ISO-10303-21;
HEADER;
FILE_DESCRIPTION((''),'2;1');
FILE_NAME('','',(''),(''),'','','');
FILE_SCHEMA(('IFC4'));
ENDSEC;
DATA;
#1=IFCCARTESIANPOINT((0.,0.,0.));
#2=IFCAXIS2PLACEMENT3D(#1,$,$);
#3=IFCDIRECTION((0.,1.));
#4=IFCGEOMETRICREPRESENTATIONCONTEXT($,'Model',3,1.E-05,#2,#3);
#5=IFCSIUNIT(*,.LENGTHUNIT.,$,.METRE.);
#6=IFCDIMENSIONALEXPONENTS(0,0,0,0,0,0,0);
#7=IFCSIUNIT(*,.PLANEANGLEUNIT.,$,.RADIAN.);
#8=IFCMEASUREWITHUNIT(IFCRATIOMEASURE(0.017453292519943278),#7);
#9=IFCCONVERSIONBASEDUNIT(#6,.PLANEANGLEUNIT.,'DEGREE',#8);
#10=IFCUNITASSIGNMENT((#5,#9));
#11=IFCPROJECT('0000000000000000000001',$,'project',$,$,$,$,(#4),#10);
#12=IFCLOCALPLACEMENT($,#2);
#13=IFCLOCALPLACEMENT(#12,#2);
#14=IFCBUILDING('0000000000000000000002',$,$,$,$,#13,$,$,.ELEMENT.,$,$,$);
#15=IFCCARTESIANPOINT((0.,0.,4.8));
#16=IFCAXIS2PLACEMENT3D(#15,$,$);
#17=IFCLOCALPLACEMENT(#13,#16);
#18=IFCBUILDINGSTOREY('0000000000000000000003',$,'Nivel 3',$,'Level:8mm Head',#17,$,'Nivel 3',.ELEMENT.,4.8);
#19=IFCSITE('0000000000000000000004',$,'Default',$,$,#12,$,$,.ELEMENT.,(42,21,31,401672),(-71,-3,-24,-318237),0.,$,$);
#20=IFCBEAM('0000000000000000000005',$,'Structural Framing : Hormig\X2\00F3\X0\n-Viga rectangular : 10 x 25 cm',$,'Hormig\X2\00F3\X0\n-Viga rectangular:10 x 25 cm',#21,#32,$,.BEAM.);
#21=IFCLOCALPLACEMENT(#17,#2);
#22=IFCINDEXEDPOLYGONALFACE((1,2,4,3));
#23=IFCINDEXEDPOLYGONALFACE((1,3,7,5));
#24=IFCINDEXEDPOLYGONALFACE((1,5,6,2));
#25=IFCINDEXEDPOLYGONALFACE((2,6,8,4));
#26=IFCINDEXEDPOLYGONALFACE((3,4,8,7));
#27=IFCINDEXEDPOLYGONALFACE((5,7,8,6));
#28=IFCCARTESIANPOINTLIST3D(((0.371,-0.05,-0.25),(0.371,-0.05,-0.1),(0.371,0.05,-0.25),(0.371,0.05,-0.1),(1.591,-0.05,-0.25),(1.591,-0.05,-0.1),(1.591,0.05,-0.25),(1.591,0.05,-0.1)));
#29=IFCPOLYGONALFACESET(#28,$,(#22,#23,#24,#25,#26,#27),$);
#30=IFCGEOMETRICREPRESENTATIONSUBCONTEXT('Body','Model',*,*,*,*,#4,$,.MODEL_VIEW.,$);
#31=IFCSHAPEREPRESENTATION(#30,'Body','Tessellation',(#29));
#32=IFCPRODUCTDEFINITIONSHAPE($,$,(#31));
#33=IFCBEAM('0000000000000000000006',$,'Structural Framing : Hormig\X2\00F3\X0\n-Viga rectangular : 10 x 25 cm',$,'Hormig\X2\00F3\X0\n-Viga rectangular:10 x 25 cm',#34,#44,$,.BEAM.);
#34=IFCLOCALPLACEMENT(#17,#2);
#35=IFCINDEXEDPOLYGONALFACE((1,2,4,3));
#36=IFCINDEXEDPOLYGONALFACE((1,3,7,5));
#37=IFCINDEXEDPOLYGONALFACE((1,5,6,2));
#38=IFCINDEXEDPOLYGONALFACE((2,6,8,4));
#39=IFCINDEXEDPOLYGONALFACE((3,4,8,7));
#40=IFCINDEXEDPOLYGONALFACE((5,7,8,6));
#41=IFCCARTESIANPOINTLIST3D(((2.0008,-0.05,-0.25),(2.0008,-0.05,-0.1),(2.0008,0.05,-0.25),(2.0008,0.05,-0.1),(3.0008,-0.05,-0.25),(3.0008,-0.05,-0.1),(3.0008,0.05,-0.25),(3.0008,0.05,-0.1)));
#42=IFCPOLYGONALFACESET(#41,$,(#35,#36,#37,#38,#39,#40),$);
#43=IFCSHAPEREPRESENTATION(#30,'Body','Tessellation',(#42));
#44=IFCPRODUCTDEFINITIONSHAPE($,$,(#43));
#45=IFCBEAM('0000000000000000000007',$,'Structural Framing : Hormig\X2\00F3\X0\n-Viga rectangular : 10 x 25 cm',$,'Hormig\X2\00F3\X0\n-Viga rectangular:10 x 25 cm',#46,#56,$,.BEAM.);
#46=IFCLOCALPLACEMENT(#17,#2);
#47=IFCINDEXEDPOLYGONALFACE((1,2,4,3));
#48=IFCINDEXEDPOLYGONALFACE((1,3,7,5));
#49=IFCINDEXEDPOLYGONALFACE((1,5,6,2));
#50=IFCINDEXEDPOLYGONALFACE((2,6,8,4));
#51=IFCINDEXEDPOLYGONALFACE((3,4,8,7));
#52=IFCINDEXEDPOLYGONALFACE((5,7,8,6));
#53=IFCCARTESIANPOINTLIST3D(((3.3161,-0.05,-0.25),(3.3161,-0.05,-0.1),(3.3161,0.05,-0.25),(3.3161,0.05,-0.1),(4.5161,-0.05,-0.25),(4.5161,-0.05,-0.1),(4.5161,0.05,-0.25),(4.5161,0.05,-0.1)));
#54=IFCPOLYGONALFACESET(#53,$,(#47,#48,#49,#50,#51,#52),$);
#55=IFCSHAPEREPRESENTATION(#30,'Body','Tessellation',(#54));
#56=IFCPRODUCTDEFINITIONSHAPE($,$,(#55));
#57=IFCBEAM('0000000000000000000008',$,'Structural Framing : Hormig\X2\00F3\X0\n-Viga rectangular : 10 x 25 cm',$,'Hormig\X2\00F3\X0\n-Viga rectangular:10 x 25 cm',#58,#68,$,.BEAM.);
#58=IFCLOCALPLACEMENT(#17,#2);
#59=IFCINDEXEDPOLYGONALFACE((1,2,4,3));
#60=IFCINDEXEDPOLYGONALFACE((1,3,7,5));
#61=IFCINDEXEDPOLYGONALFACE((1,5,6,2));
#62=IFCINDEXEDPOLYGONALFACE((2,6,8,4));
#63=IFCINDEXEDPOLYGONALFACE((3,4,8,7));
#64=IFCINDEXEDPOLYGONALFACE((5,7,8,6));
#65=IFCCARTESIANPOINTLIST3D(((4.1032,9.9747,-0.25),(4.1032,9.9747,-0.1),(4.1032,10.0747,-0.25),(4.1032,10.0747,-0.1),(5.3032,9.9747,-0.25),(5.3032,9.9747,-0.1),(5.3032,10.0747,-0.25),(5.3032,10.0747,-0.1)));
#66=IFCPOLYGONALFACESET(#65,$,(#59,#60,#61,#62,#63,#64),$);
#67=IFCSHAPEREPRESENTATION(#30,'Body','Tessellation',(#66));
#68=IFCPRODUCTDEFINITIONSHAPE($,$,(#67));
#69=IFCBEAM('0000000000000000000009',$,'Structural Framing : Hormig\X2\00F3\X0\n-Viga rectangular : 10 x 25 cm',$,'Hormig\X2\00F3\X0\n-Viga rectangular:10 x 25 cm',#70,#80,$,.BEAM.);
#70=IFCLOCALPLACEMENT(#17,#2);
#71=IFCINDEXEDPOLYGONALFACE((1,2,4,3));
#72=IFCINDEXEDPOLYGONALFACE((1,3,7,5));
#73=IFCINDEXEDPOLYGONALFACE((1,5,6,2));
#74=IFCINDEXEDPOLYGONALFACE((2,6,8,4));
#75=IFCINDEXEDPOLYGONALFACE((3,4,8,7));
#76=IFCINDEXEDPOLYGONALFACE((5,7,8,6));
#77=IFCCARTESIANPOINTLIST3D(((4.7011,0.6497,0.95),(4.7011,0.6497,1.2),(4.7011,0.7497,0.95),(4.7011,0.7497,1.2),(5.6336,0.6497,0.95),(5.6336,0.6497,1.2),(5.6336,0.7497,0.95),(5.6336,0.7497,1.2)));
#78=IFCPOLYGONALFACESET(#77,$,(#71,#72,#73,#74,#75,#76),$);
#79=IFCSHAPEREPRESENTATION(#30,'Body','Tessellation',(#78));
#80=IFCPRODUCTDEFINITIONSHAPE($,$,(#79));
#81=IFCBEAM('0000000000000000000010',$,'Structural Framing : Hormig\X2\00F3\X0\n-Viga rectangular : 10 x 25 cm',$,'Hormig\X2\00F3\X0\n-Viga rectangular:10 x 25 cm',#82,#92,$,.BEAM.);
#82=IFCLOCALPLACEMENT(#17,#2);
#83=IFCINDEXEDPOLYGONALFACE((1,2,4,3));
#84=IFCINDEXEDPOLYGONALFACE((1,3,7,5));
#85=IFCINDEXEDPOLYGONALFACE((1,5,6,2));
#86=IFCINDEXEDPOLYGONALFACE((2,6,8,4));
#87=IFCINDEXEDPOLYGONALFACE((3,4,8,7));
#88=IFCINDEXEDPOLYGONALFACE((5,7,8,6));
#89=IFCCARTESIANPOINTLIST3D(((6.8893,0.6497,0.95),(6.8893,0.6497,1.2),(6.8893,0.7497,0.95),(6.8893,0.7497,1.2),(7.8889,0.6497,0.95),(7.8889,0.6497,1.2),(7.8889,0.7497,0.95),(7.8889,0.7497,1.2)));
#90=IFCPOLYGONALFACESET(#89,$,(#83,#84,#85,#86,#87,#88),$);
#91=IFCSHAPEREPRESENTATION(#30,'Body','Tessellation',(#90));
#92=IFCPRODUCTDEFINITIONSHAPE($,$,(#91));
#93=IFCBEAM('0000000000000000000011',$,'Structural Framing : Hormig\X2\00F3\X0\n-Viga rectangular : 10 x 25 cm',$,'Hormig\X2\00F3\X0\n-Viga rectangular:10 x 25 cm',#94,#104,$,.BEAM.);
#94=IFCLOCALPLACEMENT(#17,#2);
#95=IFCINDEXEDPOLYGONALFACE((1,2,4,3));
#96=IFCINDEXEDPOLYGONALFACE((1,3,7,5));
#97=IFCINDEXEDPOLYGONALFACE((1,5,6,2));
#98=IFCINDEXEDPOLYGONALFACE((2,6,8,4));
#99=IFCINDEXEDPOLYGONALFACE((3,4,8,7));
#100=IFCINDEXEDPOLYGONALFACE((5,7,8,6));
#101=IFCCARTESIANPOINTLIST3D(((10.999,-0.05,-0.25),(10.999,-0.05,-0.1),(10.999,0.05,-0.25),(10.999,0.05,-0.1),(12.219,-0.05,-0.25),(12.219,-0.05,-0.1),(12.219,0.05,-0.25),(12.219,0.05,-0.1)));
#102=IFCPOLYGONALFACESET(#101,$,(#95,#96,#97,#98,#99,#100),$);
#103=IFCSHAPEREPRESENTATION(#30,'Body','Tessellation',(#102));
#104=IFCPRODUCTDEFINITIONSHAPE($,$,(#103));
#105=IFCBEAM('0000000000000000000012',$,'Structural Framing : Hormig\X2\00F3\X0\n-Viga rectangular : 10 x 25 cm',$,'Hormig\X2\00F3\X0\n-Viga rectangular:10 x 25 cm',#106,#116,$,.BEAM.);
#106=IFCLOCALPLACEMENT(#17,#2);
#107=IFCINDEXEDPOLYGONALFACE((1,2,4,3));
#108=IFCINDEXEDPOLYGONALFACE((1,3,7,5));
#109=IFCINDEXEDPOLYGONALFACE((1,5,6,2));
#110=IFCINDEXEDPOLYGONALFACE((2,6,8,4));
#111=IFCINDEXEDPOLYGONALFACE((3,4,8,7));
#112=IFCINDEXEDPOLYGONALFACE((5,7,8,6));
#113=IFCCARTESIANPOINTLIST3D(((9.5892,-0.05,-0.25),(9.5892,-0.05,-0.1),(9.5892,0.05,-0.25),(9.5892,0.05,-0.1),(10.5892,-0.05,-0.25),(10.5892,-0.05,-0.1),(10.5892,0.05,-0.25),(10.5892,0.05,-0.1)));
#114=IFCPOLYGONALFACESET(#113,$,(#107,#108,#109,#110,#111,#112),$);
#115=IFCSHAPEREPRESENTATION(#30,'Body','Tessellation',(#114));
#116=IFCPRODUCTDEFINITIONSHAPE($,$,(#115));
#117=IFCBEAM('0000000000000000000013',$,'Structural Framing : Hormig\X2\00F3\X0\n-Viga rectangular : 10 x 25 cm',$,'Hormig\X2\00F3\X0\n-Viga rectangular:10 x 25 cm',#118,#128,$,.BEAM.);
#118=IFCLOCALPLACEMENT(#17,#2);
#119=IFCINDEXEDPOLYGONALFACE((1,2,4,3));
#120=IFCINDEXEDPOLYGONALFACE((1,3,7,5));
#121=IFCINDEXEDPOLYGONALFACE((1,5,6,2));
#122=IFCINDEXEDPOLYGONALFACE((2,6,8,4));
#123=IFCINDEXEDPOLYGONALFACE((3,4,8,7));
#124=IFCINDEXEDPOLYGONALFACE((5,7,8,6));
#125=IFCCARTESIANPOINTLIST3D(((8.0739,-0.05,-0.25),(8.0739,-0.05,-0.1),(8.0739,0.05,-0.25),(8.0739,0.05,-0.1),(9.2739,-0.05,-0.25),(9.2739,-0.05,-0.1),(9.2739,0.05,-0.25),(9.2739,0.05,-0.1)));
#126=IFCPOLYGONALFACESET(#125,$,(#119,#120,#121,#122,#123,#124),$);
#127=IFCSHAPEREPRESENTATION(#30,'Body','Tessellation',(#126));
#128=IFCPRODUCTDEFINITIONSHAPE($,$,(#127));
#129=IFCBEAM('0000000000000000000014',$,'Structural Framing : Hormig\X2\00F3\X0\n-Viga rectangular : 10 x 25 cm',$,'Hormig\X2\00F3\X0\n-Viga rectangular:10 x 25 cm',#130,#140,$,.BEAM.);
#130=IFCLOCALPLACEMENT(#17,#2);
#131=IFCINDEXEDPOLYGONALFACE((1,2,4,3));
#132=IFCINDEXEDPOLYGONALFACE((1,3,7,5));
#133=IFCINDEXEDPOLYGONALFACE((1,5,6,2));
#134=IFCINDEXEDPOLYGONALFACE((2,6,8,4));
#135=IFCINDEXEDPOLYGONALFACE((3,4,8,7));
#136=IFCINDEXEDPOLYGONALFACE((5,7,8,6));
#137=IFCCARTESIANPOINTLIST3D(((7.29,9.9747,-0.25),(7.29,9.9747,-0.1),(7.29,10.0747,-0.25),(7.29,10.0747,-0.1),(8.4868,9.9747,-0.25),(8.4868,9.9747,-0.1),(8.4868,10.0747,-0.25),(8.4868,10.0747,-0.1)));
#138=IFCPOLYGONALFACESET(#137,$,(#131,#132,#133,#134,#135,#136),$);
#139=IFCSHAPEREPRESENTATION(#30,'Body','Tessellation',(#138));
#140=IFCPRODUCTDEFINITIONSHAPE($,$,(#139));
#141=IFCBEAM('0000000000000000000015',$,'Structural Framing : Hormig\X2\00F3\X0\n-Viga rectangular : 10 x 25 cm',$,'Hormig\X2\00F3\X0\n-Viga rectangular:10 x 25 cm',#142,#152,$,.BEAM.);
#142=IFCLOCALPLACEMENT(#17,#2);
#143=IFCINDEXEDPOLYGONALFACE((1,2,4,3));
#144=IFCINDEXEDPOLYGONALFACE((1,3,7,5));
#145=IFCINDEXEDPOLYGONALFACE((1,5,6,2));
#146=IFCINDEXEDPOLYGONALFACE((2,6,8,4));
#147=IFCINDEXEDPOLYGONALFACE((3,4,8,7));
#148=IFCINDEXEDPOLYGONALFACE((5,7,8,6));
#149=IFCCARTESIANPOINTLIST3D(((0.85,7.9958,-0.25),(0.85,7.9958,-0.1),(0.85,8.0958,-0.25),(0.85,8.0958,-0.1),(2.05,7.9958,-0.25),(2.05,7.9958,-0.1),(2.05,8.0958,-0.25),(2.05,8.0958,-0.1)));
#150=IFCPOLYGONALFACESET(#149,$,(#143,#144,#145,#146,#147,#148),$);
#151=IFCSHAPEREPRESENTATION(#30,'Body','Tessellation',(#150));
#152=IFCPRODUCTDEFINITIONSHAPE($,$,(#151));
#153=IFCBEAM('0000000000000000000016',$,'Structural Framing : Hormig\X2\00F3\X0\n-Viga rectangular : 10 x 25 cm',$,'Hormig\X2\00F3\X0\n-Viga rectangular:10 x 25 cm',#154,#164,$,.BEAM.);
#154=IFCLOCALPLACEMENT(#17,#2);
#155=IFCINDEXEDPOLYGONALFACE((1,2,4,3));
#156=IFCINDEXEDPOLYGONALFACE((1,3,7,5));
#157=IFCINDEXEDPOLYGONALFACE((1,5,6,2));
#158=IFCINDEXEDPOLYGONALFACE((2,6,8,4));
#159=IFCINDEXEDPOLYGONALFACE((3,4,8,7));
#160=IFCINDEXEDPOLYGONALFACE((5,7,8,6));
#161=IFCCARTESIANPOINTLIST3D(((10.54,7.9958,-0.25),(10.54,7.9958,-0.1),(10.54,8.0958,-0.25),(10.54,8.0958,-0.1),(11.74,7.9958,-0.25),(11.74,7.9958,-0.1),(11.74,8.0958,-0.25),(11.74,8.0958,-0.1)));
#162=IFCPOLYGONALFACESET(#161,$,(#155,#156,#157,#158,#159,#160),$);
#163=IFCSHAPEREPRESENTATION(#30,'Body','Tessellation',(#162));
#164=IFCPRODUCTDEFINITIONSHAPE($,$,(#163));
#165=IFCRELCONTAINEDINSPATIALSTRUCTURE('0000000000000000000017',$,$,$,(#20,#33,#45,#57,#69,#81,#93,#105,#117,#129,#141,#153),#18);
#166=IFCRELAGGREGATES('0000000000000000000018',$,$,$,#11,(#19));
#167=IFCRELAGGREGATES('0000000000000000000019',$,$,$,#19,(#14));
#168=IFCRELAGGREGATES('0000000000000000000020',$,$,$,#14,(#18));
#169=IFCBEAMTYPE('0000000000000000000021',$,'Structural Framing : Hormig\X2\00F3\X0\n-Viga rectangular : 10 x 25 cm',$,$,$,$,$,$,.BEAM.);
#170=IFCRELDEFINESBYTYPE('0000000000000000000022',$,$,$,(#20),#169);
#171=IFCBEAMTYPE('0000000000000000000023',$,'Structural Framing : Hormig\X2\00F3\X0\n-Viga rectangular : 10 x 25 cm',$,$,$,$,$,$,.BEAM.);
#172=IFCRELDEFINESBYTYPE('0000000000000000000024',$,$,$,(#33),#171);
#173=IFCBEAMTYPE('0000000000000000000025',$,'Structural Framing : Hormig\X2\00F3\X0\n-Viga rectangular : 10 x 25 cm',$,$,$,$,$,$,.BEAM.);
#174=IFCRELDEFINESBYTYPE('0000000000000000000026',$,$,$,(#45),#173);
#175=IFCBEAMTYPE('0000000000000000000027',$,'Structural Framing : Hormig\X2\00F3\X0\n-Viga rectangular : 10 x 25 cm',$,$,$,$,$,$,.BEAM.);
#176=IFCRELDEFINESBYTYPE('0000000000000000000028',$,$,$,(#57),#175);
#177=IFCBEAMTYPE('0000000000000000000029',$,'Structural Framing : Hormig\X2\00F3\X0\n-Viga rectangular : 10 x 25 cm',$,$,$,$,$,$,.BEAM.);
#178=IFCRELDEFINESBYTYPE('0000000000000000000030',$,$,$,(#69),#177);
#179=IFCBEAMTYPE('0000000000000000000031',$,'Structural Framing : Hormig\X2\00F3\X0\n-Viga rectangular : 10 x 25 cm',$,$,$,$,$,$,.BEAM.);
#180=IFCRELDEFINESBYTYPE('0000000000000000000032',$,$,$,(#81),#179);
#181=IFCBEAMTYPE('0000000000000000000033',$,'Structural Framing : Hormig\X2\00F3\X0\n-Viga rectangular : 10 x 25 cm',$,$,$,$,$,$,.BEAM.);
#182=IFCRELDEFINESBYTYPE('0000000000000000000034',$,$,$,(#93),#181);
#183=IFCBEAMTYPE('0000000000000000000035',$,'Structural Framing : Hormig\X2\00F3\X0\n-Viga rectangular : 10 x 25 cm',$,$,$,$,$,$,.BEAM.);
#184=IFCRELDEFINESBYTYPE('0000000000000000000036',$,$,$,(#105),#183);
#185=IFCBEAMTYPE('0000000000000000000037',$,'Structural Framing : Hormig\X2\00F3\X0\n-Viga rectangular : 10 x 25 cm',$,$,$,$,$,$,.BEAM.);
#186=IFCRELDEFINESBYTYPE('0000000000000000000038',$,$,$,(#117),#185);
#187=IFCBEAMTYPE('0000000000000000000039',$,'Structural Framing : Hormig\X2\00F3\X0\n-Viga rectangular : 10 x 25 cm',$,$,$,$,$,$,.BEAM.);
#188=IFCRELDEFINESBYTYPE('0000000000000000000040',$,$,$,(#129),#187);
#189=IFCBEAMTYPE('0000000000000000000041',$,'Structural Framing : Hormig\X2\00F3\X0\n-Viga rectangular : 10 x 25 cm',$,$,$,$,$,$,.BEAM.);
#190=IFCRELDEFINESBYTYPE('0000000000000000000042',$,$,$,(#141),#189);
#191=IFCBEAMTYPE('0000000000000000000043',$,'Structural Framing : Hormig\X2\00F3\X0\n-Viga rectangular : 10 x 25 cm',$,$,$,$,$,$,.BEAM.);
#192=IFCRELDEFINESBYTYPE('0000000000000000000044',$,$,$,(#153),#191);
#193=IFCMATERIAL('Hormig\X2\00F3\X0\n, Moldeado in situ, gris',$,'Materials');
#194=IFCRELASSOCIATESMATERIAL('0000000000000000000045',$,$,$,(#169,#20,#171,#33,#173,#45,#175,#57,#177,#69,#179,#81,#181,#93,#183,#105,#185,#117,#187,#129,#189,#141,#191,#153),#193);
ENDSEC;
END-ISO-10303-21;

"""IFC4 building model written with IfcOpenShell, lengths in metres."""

from ifc_helpers import new_model, entity, si_unit, converted_unit, direction, frame, origin, place, context, subcontext, project, spatial, indexed_curve, outline, extrude, source, transform, mapped, material, type_object, type_shapes, element, save


model = new_model("IFC4")

# Units and contexts
model_context = context("Model", 3, precision=1e-05, world=origin(), true_north=direction((0.0, 1.0)))
body_context = subcontext(model_context, "Body", "Model", "MODEL_VIEW")
ifc_project = project(units=[si_unit("LENGTHUNIT", "METRE"), converted_unit("PLANEANGLEUNIT", "DEGREE", entity("IfcRatioMeasure", 0.017453292519943278), si_unit("PLANEANGLEUNIT", "RADIAN"), dimensions=[0, 0, 0, 0, 0, 0, 0])], contexts=[model_context])

# Site, building, storey
site_placement = place(None, origin())
site = spatial("IfcSite", under=ifc_project, at=site_placement, Name="Default", CompositionType="ELEMENT", RefLatitude=(42, 21, 31, 401672), RefLongitude=(-71, -3, -24, -318237), RefElevation=0.0)
building_placement = place(site_placement, origin())
building = spatial("IfcBuilding", under=site, at=building_placement, CompositionType="ELEMENT")
storey_placement = place(building_placement, frame((0.0, 0.0, 4.8)))
storey = spatial("IfcBuildingStorey", under=building, at=storey_placement, Name="Nivel 3", ObjectType="Level:8mm Head", LongName="Nivel 3", CompositionType="ELEMENT", Elevation=4.8)

# Beams
ifc_material_1 = material(Name="Hormigón, Moldeado in situ, gris", Category="Materials")
beam_type_1 = type_object("IfcBeamType", Name="Structural Framing : Hormigón-Viga rectangular : 10 x 25 cm", PredefinedType="BEAM", material=ifc_material_1)
shared_shape_1 = source(origin(), body_context, "Body", "SweptSolid", [
    extrude(outline(indexed_curve([(-0.075, -0.05), (0.075, -0.05), (0.075, 0.05), (-0.075, 0.05), (-0.075, -0.05)], self_intersect=False)), frame((0.371, 0.0, 4.625), z_axis=(1.0, 0.0, 0.0), x_axis=(0.0, 0.0, -1.0)), (0.0, 0.0, 1.0), 1.22),
])
type_shapes(beam_type_1, [shared_shape_1])
beam_1_placement = place(storey_placement, frame((0.0, 0.0, -4.8)))
element("IfcBeam", 1, at=beam_1_placement, inside=storey, type_object=beam_type_1, material=ifc_material_1, Name="Structural Framing : Hormigón-Viga rectangular : 10 x 25 cm", ObjectType="Hormigón-Viga rectangular:10 x 25 cm", PredefinedType="BEAM", context=body_context, shape_type="MappedRepresentation", body=[
    mapped(shared_shape_1, transform((0.0, 0.0, 0.0), scale=1.0)),
])
beam_type_2 = type_object("IfcBeamType", Name="Structural Framing : Hormigón-Viga rectangular : 10 x 25 cm", PredefinedType="BEAM", material=ifc_material_1)
shared_shape_2 = source(origin(), body_context, "Body", "SweptSolid", [
    extrude(outline(indexed_curve([(-0.075, -0.05), (0.075, -0.05), (0.075, 0.05), (-0.075, 0.05), (-0.075, -0.05)], self_intersect=False)), frame((2.0008, 0.0, 4.625), z_axis=(1.0, 0.0, 0.0), x_axis=(0.0, 0.0, -1.0)), (0.0, 0.0, 1.0), 1.0),
])
type_shapes(beam_type_2, [shared_shape_2])
beam_2_placement = place(storey_placement, frame((0.0, 0.0, -4.8)))
element("IfcBeam", 2, at=beam_2_placement, inside=storey, type_object=beam_type_2, material=ifc_material_1, Name="Structural Framing : Hormigón-Viga rectangular : 10 x 25 cm", ObjectType="Hormigón-Viga rectangular:10 x 25 cm", PredefinedType="BEAM", context=body_context, shape_type="MappedRepresentation", body=[
    mapped(shared_shape_2, transform((0.0, 0.0, 0.0), scale=1.0)),
])
beam_type_3 = type_object("IfcBeamType", Name="Structural Framing : Hormigón-Viga rectangular : 10 x 25 cm", PredefinedType="BEAM", material=ifc_material_1)
shared_shape_3 = source(origin(), body_context, "Body", "SweptSolid", [
    extrude(outline(indexed_curve([(-0.075, -0.05), (0.075, -0.05), (0.075, 0.05), (-0.075, 0.05), (-0.075, -0.05)], self_intersect=False)), frame((3.3161, 0.0, 4.625), z_axis=(1.0, 0.0, 0.0), x_axis=(0.0, 0.0, -1.0)), (0.0, 0.0, 1.0), 1.2),
])
type_shapes(beam_type_3, [shared_shape_3])
beam_3_placement = place(storey_placement, frame((0.0, 0.0, -4.8)))
element("IfcBeam", 3, at=beam_3_placement, inside=storey, type_object=beam_type_3, material=ifc_material_1, Name="Structural Framing : Hormigón-Viga rectangular : 10 x 25 cm", ObjectType="Hormigón-Viga rectangular:10 x 25 cm", PredefinedType="BEAM", context=body_context, shape_type="MappedRepresentation", body=[
    mapped(shared_shape_3, transform((0.0, 0.0, 0.0), scale=1.0)),
])
beam_type_4 = type_object("IfcBeamType", Name="Structural Framing : Hormigón-Viga rectangular : 10 x 25 cm", PredefinedType="BEAM", material=ifc_material_1)
shared_shape_4 = source(origin(), body_context, "Body", "SweptSolid", [
    extrude(outline(indexed_curve([(-0.075, -0.05), (0.075, -0.05), (0.075, 0.05), (-0.075, 0.05), (-0.075, -0.05)], self_intersect=False)), frame((5.3032, 10.0247, 4.625), z_axis=(-1.0, 0.0, 0.0), x_axis=(0.0, 0.0, -1.0)), (0.0, 0.0, 1.0), 1.2),
])
type_shapes(beam_type_4, [shared_shape_4])
beam_4_placement = place(storey_placement, frame((0.0, 0.0, -4.8)))
element("IfcBeam", 4, at=beam_4_placement, inside=storey, type_object=beam_type_4, material=ifc_material_1, Name="Structural Framing : Hormigón-Viga rectangular : 10 x 25 cm", ObjectType="Hormigón-Viga rectangular:10 x 25 cm", PredefinedType="BEAM", context=body_context, shape_type="MappedRepresentation", body=[
    mapped(shared_shape_4, transform((0.0, 0.0, 0.0), scale=1.0)),
])
beam_type_5 = type_object("IfcBeamType", Name="Structural Framing : Hormigón-Viga rectangular : 10 x 25 cm", PredefinedType="BEAM", material=ifc_material_1)
shared_shape_5 = source(origin(), body_context, "Body", "SweptSolid", [
    extrude(outline(indexed_curve([(-0.125, -0.05), (0.125, -0.05), (0.125, 0.05), (-0.125, 0.05), (-0.125, -0.05)], self_intersect=False)), frame((5.6336, 0.6997, 5.875), z_axis=(-1.0, 0.0, 0.0), x_axis=(0.0, 0.0, -1.0)), (0.0, 0.0, 1.0), 0.9325),
])
type_shapes(beam_type_5, [shared_shape_5])
beam_5_placement = place(storey_placement, frame((0.0, 0.0, -4.8)))
element("IfcBeam", 5, at=beam_5_placement, inside=storey, type_object=beam_type_5, material=ifc_material_1, Name="Structural Framing : Hormigón-Viga rectangular : 10 x 25 cm", ObjectType="Hormigón-Viga rectangular:10 x 25 cm", PredefinedType="BEAM", context=body_context, shape_type="MappedRepresentation", body=[
    mapped(shared_shape_5, transform((0.0, 0.0, 0.0), scale=1.0)),
])
beam_type_6 = type_object("IfcBeamType", Name="Structural Framing : Hormigón-Viga rectangular : 10 x 25 cm", PredefinedType="BEAM", material=ifc_material_1)
shared_shape_6 = source(origin(), body_context, "Body", "SweptSolid", [
    extrude(outline(indexed_curve([(-0.125, -0.05), (0.125, -0.05), (0.125, 0.05), (-0.125, 0.05), (-0.125, -0.05)], self_intersect=False)), frame((7.8889, 0.6997, 5.875), z_axis=(-1.0, 0.0, 0.0), x_axis=(0.0, 0.0, -1.0)), (0.0, 0.0, 1.0), 0.9996),
])
type_shapes(beam_type_6, [shared_shape_6])
beam_6_placement = place(storey_placement, frame((0.0, 0.0, -4.8)))
element("IfcBeam", 6, at=beam_6_placement, inside=storey, type_object=beam_type_6, material=ifc_material_1, Name="Structural Framing : Hormigón-Viga rectangular : 10 x 25 cm", ObjectType="Hormigón-Viga rectangular:10 x 25 cm", PredefinedType="BEAM", context=body_context, shape_type="MappedRepresentation", body=[
    mapped(shared_shape_6, transform((0.0, 0.0, 0.0), scale=1.0)),
])
beam_type_7 = type_object("IfcBeamType", Name="Structural Framing : Hormigón-Viga rectangular : 10 x 25 cm", PredefinedType="BEAM", material=ifc_material_1)
shared_shape_7 = source(origin(), body_context, "Body", "SweptSolid", [
    extrude(outline(indexed_curve([(-0.075, -0.05), (0.075, -0.05), (0.075, 0.05), (-0.075, 0.05), (-0.075, -0.05)], self_intersect=False)), frame((12.219, 0.0, 4.625), z_axis=(-1.0, 0.0, 0.0), x_axis=(0.0, 0.0, -1.0)), (0.0, 0.0, 1.0), 1.22),
])
type_shapes(beam_type_7, [shared_shape_7])
beam_7_placement = place(storey_placement, frame((0.0, 0.0, -4.8)))
element("IfcBeam", 7, at=beam_7_placement, inside=storey, type_object=beam_type_7, material=ifc_material_1, Name="Structural Framing : Hormigón-Viga rectangular : 10 x 25 cm", ObjectType="Hormigón-Viga rectangular:10 x 25 cm", PredefinedType="BEAM", context=body_context, shape_type="MappedRepresentation", body=[
    mapped(shared_shape_7, transform((0.0, 0.0, 0.0), scale=1.0)),
])
beam_type_8 = type_object("IfcBeamType", Name="Structural Framing : Hormigón-Viga rectangular : 10 x 25 cm", PredefinedType="BEAM", material=ifc_material_1)
shared_shape_8 = source(origin(), body_context, "Body", "SweptSolid", [
    extrude(outline(indexed_curve([(-0.075, -0.05), (0.075, -0.05), (0.075, 0.05), (-0.075, 0.05), (-0.075, -0.05)], self_intersect=False)), frame((10.5892, 0.0, 4.625), z_axis=(-1.0, 0.0, 0.0), x_axis=(0.0, 0.0, -1.0)), (0.0, 0.0, 1.0), 1.0),
])
type_shapes(beam_type_8, [shared_shape_8])
beam_8_placement = place(storey_placement, frame((0.0, 0.0, -4.8)))
element("IfcBeam", 8, at=beam_8_placement, inside=storey, type_object=beam_type_8, material=ifc_material_1, Name="Structural Framing : Hormigón-Viga rectangular : 10 x 25 cm", ObjectType="Hormigón-Viga rectangular:10 x 25 cm", PredefinedType="BEAM", context=body_context, shape_type="MappedRepresentation", body=[
    mapped(shared_shape_8, transform((0.0, 0.0, 0.0), scale=1.0)),
])
beam_type_9 = type_object("IfcBeamType", Name="Structural Framing : Hormigón-Viga rectangular : 10 x 25 cm", PredefinedType="BEAM", material=ifc_material_1)
shared_shape_9 = source(origin(), body_context, "Body", "SweptSolid", [
    extrude(outline(indexed_curve([(-0.075, -0.05), (0.075, -0.05), (0.075, 0.05), (-0.075, 0.05), (-0.075, -0.05)], self_intersect=False)), frame((9.2739, 0.0, 4.625), z_axis=(-1.0, 0.0, 0.0), x_axis=(0.0, 0.0, -1.0)), (0.0, 0.0, 1.0), 1.2),
])
type_shapes(beam_type_9, [shared_shape_9])
beam_9_placement = place(storey_placement, frame((0.0, 0.0, -4.8)))
element("IfcBeam", 9, at=beam_9_placement, inside=storey, type_object=beam_type_9, material=ifc_material_1, Name="Structural Framing : Hormigón-Viga rectangular : 10 x 25 cm", ObjectType="Hormigón-Viga rectangular:10 x 25 cm", PredefinedType="BEAM", context=body_context, shape_type="MappedRepresentation", body=[
    mapped(shared_shape_9, transform((0.0, 0.0, 0.0), scale=1.0)),
])
beam_type_10 = type_object("IfcBeamType", Name="Structural Framing : Hormigón-Viga rectangular : 10 x 25 cm", PredefinedType="BEAM", material=ifc_material_1)
shared_shape_10 = source(origin(), body_context, "Body", "SweptSolid", [
    extrude(outline(indexed_curve([(-0.075, -0.05), (0.075, -0.05), (0.075, 0.05), (-0.075, 0.05), (-0.075, -0.05)], self_intersect=False)), frame((7.29, 10.0247, 4.625), z_axis=(1.0, 0.0, 0.0), x_axis=(0.0, 0.0, -1.0)), (0.0, 0.0, 1.0), 1.1968),
])
type_shapes(beam_type_10, [shared_shape_10])
beam_10_placement = place(storey_placement, frame((0.0, 0.0, -4.8)))
element("IfcBeam", 10, at=beam_10_placement, inside=storey, type_object=beam_type_10, material=ifc_material_1, Name="Structural Framing : Hormigón-Viga rectangular : 10 x 25 cm", ObjectType="Hormigón-Viga rectangular:10 x 25 cm", PredefinedType="BEAM", context=body_context, shape_type="MappedRepresentation", body=[
    mapped(shared_shape_10, transform((0.0, 0.0, 0.0), scale=1.0)),
])
beam_type_11 = type_object("IfcBeamType", Name="Structural Framing : Hormigón-Viga rectangular : 10 x 25 cm", PredefinedType="BEAM", material=ifc_material_1)
shared_shape_11 = source(origin(), body_context, "Body", "SweptSolid", [
    extrude(outline(indexed_curve([(-0.075, -0.05), (0.075, -0.05), (0.075, 0.05), (-0.075, 0.05), (-0.075, -0.05)], self_intersect=False)), frame((2.05, 8.0458, 4.625), z_axis=(-1.0, 0.0, 0.0), x_axis=(0.0, 0.0, -1.0)), (0.0, 0.0, 1.0), 1.2),
])
type_shapes(beam_type_11, [shared_shape_11])
beam_11_placement = place(storey_placement, frame((0.0, 0.0, -4.8)))
element("IfcBeam", 11, at=beam_11_placement, inside=storey, type_object=beam_type_11, material=ifc_material_1, Name="Structural Framing : Hormigón-Viga rectangular : 10 x 25 cm", ObjectType="Hormigón-Viga rectangular:10 x 25 cm", PredefinedType="BEAM", context=body_context, shape_type="MappedRepresentation", body=[
    mapped(shared_shape_11, transform((0.0, 0.0, 0.0), scale=1.0)),
])
beam_type_12 = type_object("IfcBeamType", Name="Structural Framing : Hormigón-Viga rectangular : 10 x 25 cm", PredefinedType="BEAM", material=ifc_material_1)
shared_shape_12 = source(origin(), body_context, "Body", "SweptSolid", [
    extrude(outline(indexed_curve([(-0.075, -0.05), (0.075, -0.05), (0.075, 0.05), (-0.075, 0.05), (-0.075, -0.05)], self_intersect=False)), frame((10.54, 8.0458, 4.625), z_axis=(1.0, 0.0, 0.0), x_axis=(0.0, 0.0, -1.0)), (0.0, 0.0, 1.0), 1.2),
])
type_shapes(beam_type_12, [shared_shape_12])
beam_12_placement = place(storey_placement, frame((0.0, 0.0, -4.8)))
element("IfcBeam", 12, at=beam_12_placement, inside=storey, type_object=beam_type_12, material=ifc_material_1, Name="Structural Framing : Hormigón-Viga rectangular : 10 x 25 cm", ObjectType="Hormigón-Viga rectangular:10 x 25 cm", PredefinedType="BEAM", context=body_context, shape_type="MappedRepresentation", body=[
    mapped(shared_shape_12, transform((0.0, 0.0, 0.0), scale=1.0)),
])

save(model, "model.ifc")
